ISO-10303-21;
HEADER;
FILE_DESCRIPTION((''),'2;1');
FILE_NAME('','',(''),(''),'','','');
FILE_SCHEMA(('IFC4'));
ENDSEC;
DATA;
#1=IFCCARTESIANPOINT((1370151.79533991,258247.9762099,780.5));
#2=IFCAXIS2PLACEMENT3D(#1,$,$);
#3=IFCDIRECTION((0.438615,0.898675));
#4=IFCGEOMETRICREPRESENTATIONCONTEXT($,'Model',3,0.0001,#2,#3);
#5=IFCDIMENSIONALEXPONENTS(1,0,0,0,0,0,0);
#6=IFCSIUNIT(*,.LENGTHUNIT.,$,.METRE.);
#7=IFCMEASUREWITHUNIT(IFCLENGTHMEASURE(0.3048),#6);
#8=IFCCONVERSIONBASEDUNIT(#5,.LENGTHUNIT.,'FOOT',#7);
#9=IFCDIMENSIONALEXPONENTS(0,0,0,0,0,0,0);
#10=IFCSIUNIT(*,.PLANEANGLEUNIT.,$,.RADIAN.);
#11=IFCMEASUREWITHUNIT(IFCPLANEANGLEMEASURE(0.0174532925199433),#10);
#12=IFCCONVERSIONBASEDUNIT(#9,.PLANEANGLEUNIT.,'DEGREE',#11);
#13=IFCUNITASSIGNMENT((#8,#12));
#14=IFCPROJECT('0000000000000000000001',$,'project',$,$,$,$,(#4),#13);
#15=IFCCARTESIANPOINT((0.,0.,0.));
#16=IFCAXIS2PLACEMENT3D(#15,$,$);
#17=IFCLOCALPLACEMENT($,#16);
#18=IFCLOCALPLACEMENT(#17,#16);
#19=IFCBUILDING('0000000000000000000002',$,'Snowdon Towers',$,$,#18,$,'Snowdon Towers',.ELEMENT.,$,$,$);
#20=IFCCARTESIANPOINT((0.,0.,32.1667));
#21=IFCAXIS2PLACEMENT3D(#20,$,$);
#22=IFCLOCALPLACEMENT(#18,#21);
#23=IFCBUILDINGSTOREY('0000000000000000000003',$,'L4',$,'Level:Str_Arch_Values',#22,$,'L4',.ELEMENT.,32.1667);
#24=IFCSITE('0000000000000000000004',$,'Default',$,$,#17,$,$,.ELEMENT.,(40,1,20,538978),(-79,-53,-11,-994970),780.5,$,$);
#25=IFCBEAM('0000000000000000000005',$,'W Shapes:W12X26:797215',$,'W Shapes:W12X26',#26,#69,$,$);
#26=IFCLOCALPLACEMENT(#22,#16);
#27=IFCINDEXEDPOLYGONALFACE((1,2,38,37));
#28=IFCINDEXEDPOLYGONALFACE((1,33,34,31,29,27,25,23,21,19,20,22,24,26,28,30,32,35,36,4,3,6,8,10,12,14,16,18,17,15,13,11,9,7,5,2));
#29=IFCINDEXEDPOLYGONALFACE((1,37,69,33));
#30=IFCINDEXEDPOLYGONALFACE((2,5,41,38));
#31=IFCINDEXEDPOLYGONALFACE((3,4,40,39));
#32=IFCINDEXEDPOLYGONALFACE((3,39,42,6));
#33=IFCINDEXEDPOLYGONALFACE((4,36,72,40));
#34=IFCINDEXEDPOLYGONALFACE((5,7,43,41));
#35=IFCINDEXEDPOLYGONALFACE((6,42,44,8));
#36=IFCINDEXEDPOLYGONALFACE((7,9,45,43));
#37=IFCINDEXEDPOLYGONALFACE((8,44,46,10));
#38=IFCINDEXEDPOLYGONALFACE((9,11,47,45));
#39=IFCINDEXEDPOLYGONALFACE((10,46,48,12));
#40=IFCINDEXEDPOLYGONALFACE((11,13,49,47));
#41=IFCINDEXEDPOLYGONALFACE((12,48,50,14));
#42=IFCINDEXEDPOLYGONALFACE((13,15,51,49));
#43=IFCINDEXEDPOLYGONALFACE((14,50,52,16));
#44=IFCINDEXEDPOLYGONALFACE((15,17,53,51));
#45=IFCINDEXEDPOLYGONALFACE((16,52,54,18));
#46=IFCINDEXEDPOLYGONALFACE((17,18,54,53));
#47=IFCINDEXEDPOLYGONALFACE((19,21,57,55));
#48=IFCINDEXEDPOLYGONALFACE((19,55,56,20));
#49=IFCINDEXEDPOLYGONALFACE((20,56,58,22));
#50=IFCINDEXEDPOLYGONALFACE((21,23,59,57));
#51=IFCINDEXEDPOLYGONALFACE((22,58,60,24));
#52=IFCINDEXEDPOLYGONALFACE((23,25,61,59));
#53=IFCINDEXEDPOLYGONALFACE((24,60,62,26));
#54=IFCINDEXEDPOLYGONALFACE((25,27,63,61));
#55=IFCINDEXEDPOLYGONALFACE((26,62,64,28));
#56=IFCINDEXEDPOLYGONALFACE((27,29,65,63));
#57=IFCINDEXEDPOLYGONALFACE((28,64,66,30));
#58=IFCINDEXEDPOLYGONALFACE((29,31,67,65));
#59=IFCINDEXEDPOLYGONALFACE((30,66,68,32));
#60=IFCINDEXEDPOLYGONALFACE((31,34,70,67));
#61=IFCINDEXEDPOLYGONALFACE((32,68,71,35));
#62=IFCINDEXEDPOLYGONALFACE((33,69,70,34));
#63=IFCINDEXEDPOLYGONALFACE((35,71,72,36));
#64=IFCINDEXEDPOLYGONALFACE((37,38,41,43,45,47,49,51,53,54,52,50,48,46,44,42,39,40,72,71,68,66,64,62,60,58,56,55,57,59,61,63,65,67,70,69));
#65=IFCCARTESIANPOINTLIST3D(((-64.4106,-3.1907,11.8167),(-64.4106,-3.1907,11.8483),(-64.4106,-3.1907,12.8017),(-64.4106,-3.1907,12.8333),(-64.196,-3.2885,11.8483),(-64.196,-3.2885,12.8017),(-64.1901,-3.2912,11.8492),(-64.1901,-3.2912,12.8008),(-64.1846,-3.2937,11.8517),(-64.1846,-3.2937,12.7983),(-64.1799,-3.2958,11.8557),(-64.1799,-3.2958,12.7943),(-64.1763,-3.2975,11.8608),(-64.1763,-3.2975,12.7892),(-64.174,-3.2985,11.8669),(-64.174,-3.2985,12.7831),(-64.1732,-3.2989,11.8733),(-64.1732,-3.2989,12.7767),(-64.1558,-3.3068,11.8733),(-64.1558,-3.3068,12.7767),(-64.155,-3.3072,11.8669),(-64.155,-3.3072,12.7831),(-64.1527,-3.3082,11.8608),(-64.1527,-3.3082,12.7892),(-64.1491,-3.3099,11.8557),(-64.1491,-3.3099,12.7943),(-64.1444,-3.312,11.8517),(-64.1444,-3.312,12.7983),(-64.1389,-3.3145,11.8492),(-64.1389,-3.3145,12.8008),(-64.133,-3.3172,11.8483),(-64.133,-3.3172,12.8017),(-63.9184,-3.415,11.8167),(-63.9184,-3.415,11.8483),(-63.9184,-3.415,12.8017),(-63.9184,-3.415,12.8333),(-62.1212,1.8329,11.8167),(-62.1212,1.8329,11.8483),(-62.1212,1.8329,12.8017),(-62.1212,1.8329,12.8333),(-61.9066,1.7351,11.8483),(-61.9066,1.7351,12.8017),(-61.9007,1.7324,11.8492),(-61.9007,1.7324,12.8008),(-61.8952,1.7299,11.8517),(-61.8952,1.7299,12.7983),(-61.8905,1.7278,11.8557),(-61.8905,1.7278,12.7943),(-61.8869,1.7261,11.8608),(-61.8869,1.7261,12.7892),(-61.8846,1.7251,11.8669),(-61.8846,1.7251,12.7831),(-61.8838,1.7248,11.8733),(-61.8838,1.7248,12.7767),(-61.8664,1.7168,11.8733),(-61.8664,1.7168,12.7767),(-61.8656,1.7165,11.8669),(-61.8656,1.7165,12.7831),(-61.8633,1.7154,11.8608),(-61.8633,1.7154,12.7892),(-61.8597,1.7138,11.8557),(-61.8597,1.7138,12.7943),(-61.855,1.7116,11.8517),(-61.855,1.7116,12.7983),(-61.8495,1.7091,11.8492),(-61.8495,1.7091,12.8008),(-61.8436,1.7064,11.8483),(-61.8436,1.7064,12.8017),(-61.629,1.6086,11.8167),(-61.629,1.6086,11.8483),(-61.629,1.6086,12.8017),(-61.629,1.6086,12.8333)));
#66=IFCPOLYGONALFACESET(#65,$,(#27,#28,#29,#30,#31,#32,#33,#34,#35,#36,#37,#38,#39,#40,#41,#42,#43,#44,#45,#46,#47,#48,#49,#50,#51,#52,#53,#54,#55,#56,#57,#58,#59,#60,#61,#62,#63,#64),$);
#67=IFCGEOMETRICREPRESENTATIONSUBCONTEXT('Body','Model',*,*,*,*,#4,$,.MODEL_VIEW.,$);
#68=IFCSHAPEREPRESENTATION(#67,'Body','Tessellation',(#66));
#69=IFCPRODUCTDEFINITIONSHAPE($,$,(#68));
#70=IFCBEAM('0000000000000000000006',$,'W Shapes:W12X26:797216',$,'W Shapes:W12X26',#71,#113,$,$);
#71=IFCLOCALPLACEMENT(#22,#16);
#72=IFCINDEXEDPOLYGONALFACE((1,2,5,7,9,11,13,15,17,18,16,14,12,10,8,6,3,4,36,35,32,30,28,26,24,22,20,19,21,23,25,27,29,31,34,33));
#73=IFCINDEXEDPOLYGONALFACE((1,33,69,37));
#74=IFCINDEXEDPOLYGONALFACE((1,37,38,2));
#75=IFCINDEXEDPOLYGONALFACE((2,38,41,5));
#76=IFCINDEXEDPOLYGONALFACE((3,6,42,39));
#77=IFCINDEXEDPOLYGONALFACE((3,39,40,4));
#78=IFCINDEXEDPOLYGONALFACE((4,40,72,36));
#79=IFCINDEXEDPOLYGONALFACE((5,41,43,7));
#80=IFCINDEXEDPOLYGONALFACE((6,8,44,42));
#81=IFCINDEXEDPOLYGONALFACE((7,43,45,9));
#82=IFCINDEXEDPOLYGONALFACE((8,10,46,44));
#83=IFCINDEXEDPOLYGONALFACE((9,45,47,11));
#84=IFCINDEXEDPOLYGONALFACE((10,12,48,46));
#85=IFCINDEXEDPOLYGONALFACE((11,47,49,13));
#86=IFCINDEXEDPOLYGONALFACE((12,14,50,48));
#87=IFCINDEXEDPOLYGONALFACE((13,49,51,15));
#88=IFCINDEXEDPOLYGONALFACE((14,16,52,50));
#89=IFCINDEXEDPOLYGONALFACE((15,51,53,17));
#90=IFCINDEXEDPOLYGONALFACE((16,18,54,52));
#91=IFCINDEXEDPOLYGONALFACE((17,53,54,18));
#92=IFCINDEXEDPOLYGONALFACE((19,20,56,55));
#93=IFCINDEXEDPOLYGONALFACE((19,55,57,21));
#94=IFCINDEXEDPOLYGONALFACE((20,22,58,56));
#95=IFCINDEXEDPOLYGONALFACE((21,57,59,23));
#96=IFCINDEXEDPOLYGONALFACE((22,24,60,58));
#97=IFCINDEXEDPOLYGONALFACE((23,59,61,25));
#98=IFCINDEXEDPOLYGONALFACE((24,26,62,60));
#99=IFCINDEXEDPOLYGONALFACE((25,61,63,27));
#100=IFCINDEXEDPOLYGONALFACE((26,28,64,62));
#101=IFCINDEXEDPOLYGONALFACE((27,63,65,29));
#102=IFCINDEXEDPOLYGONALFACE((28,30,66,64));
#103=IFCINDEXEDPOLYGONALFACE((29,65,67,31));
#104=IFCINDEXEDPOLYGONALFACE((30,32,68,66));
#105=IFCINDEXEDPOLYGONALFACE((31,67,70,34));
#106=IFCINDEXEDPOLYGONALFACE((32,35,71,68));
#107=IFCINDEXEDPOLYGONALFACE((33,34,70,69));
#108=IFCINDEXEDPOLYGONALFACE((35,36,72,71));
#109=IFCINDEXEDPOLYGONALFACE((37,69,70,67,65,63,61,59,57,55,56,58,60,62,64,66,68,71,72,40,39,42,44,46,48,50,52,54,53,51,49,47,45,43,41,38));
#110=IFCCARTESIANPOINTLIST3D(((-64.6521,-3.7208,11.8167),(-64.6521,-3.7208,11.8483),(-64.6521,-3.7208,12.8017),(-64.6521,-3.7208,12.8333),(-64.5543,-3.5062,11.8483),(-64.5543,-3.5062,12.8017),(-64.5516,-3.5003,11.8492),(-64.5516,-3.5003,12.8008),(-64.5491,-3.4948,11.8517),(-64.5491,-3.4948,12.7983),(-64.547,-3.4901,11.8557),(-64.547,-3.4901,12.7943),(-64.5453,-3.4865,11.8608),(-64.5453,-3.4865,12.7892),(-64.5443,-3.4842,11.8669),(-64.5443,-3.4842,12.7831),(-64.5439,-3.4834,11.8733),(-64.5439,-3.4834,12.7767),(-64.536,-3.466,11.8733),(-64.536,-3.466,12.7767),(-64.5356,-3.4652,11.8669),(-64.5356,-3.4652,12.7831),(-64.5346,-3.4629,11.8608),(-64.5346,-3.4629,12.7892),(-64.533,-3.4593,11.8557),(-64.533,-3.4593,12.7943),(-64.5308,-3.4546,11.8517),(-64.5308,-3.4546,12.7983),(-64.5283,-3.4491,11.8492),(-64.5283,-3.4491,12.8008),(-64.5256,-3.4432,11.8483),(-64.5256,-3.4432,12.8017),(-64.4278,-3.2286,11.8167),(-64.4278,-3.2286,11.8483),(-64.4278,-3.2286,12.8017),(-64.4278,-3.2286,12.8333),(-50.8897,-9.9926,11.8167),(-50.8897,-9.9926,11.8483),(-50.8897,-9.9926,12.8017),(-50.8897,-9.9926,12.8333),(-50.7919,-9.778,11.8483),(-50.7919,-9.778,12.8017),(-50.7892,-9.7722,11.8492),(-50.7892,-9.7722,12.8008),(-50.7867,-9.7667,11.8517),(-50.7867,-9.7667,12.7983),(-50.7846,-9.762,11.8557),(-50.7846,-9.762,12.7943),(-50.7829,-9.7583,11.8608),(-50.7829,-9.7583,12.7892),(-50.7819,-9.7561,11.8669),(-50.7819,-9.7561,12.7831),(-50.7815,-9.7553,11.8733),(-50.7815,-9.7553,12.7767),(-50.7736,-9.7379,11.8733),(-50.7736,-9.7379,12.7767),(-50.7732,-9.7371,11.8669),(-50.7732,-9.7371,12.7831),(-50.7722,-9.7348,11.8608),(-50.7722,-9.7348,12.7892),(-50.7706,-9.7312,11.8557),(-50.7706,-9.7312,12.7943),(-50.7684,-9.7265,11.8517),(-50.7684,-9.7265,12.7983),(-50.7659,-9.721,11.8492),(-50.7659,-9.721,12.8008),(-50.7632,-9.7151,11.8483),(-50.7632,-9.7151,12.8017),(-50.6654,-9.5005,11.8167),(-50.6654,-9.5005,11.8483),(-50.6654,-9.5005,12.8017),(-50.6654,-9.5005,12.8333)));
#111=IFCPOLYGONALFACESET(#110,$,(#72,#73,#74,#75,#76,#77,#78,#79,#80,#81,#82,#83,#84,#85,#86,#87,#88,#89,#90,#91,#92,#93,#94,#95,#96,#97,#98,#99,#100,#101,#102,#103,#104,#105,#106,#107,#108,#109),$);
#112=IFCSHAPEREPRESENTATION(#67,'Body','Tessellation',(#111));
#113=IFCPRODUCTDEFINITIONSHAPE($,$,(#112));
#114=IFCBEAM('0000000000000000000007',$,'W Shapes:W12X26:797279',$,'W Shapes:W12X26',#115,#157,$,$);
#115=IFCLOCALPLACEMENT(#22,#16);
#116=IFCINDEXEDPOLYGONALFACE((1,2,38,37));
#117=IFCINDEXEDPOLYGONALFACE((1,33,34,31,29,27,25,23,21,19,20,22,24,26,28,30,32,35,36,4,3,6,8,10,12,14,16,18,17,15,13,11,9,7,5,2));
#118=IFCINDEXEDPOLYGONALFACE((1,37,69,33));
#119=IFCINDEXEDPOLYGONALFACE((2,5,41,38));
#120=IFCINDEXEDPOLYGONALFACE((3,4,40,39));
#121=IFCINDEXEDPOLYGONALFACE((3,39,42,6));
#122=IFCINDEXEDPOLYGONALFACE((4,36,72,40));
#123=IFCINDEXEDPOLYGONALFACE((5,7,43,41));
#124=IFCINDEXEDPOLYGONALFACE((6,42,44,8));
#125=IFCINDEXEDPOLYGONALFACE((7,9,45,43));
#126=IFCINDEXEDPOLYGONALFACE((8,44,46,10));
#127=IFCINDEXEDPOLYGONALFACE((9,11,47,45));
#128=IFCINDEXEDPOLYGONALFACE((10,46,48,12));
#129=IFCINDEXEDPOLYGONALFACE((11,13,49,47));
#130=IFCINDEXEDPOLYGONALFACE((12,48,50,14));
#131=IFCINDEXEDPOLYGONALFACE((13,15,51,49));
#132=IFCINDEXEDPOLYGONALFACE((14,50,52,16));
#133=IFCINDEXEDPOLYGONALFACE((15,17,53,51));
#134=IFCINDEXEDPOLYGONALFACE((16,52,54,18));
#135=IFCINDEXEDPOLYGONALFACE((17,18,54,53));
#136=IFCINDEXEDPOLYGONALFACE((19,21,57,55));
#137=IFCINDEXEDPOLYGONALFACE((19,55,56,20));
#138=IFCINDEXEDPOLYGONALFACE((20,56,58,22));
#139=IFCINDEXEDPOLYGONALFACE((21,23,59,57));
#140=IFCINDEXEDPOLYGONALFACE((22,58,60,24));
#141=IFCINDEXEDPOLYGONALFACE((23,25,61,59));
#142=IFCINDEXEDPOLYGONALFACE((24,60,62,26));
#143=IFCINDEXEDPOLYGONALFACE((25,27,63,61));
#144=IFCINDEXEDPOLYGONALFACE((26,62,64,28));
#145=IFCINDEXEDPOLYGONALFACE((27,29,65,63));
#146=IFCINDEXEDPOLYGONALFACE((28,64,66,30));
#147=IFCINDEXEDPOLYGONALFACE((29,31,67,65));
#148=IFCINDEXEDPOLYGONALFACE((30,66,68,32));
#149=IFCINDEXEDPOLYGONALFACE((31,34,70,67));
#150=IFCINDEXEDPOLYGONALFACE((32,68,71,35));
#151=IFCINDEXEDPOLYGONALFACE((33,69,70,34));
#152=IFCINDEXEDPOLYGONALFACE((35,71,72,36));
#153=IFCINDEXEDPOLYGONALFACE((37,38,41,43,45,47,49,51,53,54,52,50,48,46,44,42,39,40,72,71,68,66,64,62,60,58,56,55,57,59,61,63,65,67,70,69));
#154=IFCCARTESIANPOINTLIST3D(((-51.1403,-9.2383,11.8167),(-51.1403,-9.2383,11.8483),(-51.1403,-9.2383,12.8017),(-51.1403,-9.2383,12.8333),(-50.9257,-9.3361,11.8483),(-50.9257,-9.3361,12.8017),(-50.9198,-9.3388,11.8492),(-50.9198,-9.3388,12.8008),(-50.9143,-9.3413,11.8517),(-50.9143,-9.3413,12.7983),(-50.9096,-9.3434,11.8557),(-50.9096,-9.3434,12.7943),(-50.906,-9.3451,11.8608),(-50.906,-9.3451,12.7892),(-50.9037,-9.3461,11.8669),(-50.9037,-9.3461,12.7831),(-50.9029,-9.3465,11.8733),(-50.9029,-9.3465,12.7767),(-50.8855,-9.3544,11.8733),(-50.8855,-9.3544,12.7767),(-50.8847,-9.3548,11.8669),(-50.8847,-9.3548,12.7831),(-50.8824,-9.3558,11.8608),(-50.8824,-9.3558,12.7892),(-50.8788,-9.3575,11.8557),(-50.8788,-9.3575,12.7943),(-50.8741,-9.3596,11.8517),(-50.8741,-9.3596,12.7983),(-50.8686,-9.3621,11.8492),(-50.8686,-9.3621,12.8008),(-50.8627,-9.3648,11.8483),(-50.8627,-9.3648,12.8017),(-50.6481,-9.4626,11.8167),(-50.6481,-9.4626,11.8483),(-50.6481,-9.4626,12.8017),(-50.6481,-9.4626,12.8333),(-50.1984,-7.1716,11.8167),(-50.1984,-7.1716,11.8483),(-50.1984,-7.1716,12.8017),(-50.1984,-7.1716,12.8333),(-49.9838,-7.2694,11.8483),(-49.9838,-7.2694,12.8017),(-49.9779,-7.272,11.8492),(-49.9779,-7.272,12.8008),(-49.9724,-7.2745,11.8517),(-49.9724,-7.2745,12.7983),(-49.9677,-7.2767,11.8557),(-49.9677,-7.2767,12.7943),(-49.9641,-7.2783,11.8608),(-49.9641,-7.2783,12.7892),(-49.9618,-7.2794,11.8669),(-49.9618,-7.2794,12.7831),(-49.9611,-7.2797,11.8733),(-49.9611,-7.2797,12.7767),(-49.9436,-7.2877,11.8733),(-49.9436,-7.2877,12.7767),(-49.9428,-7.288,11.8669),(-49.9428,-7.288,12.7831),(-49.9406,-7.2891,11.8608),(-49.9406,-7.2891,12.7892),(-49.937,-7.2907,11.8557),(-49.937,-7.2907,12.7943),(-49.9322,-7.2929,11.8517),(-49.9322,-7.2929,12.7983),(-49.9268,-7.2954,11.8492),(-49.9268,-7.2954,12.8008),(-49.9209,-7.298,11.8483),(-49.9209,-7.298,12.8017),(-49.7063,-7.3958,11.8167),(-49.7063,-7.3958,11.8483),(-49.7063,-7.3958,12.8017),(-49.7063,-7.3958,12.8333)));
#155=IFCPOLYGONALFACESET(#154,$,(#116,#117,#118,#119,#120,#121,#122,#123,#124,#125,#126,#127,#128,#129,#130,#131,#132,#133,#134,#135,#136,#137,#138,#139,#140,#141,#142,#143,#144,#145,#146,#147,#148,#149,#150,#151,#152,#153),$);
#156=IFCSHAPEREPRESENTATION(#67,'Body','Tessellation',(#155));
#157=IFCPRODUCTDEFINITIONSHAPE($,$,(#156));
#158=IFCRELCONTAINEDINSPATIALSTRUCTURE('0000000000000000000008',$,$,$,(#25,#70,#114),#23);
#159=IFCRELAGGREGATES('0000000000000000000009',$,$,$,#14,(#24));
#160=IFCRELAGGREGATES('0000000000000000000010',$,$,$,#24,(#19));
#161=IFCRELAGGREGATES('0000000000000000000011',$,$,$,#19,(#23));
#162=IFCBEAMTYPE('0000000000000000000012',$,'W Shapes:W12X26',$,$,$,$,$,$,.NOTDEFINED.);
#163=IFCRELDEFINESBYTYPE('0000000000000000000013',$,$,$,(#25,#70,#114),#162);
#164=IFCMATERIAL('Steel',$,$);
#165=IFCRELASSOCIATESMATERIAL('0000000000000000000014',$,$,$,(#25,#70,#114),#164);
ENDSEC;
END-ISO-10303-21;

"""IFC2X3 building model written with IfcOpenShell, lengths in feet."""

from ifc_helpers import new_model, entity, si_unit, converted_unit, direction, frame, frame_2d, origin, place, context, subcontext, project, spatial, i_section, extrude, material, type_object, element, save


model = new_model("IFC2X3")

# Units and contexts
model_context = context("Model", 3, precision=0.0001, world=frame((1370151.79533991, 258247.9762099, 780.5)), true_north=direction((0.438615, 0.898675)))
body_context = subcontext(model_context, "Body", "Model", "MODEL_VIEW")
ifc_project = project(units=[converted_unit("LENGTHUNIT", "FOOT", entity("IfcLengthMeasure", 0.3048), si_unit("LENGTHUNIT", "METRE"), dimensions=[1, 0, 0, 0, 0, 0, 0]), converted_unit("PLANEANGLEUNIT", "DEGREE", entity("IfcPlaneAngleMeasure", 0.0174532925199433), si_unit("PLANEANGLEUNIT", "RADIAN"), dimensions=[0, 0, 0, 0, 0, 0, 0])], contexts=[model_context])

# Site, building, storey
site_placement = place(None, origin())
site = spatial("IfcSite", under=ifc_project, at=site_placement, Name="Default", CompositionType="ELEMENT", RefLatitude=(40, 1, 20, 538978), RefLongitude=(-79, -53, -11, -994970), RefElevation=780.5)
building_placement = place(site_placement, origin())
building = spatial("IfcBuilding", under=site, at=building_placement, Name="Snowdon Towers", LongName="Snowdon Towers", CompositionType="ELEMENT")
storey_placement = place(building_placement, frame((0.0, 0.0, 32.1667)))
storey = spatial("IfcBuildingStorey", under=building, at=storey_placement, Name="L4", ObjectType="Level:Str_Arch_Values", LongName="L4", CompositionType="ELEMENT", Elevation=32.1667)

# Shared definitions
ifc_material_1 = material(Name="Steel")

# Beams
beam_type_1 = type_object("IfcBeamType", Name="W Shapes:W12X26", PredefinedType="NOTDEFINED")
beam_1_placement = place(storey_placement, frame((-64.2939, -3.5868, 12.8333), z_axis=(0.0, 0.0, 1.0), x_axis=(0.414693, 0.909961, 0.0)))
element("IfcBeam", 1, at=beam_1_placement, inside=storey, type_object=beam_type_1, material=ifc_material_1, Name="W Shapes:W12X26:797215", ObjectType="W Shapes:W12X26", context=body_context, shape_type="SweptSolid", body=[
    extrude(i_section(OverallWidth=0.5408, OverallDepth=1.0167, WebThickness=0.0192, FlangeThickness=0.0317, FilletRadius=0.025, at=frame_2d((0.0, 0.0), x_axis=(0.0, 1.0))), frame((0.3121, 0.0, -0.5083), z_axis=(1.0, 0.0, 0.0), x_axis=(0.0, 0.0, -1.0)), (0.0, 0.0, 1.0), 5.5207),
])
beam_2_placement = place(storey_placement, frame((-64.2939, -3.5868, 12.8333), z_axis=(0.0, 0.0, 1.0), x_axis=(0.909961, -0.414693, 0.0)))
element("IfcBeam", 2, at=beam_2_placement, inside=storey, type_object=beam_type_1, material=ifc_material_1, Name="W Shapes:W12X26:797216", ObjectType="W Shapes:W12X26", context=body_context, shape_type="SweptSolid", body=[
    extrude(i_section(OverallWidth=0.5408, OverallDepth=1.0167, WebThickness=0.0192, FlangeThickness=0.0317, FilletRadius=0.025, at=frame_2d((0.0, 0.0), x_axis=(0.0, 1.0))), frame((-0.2704, 0.0, -0.5083), z_axis=(1.0, 0.0, 0.0), x_axis=(0.0, 0.0, -1.0)), (0.0, 0.0, 1.0), 15.1242),
])
beam_3_placement = place(storey_placement, frame((-51.0236, -9.6344, 12.8333), z_axis=(0.0, 0.0, 1.0), x_axis=(0.414693, 0.909961, 0.0)))
element("IfcBeam", 3, at=beam_3_placement, inside=storey, type_object=beam_type_1, material=ifc_material_1, Name="W Shapes:W12X26:797279", ObjectType="W Shapes:W12X26", context=body_context, shape_type="SweptSolid", body=[
    extrude(i_section(OverallWidth=0.5408, OverallDepth=1.0167, WebThickness=0.0192, FlangeThickness=0.0317, FilletRadius=0.025, at=frame_2d((0.0, 0.0), x_axis=(0.0, 1.0))), frame((0.3121, 0.0, -0.5083), z_axis=(1.0, 0.0, 0.0), x_axis=(0.0, 0.0, -1.0)), (0.0, 0.0, 1.0), 2.2713),
])

save(model, "model.ifc")
